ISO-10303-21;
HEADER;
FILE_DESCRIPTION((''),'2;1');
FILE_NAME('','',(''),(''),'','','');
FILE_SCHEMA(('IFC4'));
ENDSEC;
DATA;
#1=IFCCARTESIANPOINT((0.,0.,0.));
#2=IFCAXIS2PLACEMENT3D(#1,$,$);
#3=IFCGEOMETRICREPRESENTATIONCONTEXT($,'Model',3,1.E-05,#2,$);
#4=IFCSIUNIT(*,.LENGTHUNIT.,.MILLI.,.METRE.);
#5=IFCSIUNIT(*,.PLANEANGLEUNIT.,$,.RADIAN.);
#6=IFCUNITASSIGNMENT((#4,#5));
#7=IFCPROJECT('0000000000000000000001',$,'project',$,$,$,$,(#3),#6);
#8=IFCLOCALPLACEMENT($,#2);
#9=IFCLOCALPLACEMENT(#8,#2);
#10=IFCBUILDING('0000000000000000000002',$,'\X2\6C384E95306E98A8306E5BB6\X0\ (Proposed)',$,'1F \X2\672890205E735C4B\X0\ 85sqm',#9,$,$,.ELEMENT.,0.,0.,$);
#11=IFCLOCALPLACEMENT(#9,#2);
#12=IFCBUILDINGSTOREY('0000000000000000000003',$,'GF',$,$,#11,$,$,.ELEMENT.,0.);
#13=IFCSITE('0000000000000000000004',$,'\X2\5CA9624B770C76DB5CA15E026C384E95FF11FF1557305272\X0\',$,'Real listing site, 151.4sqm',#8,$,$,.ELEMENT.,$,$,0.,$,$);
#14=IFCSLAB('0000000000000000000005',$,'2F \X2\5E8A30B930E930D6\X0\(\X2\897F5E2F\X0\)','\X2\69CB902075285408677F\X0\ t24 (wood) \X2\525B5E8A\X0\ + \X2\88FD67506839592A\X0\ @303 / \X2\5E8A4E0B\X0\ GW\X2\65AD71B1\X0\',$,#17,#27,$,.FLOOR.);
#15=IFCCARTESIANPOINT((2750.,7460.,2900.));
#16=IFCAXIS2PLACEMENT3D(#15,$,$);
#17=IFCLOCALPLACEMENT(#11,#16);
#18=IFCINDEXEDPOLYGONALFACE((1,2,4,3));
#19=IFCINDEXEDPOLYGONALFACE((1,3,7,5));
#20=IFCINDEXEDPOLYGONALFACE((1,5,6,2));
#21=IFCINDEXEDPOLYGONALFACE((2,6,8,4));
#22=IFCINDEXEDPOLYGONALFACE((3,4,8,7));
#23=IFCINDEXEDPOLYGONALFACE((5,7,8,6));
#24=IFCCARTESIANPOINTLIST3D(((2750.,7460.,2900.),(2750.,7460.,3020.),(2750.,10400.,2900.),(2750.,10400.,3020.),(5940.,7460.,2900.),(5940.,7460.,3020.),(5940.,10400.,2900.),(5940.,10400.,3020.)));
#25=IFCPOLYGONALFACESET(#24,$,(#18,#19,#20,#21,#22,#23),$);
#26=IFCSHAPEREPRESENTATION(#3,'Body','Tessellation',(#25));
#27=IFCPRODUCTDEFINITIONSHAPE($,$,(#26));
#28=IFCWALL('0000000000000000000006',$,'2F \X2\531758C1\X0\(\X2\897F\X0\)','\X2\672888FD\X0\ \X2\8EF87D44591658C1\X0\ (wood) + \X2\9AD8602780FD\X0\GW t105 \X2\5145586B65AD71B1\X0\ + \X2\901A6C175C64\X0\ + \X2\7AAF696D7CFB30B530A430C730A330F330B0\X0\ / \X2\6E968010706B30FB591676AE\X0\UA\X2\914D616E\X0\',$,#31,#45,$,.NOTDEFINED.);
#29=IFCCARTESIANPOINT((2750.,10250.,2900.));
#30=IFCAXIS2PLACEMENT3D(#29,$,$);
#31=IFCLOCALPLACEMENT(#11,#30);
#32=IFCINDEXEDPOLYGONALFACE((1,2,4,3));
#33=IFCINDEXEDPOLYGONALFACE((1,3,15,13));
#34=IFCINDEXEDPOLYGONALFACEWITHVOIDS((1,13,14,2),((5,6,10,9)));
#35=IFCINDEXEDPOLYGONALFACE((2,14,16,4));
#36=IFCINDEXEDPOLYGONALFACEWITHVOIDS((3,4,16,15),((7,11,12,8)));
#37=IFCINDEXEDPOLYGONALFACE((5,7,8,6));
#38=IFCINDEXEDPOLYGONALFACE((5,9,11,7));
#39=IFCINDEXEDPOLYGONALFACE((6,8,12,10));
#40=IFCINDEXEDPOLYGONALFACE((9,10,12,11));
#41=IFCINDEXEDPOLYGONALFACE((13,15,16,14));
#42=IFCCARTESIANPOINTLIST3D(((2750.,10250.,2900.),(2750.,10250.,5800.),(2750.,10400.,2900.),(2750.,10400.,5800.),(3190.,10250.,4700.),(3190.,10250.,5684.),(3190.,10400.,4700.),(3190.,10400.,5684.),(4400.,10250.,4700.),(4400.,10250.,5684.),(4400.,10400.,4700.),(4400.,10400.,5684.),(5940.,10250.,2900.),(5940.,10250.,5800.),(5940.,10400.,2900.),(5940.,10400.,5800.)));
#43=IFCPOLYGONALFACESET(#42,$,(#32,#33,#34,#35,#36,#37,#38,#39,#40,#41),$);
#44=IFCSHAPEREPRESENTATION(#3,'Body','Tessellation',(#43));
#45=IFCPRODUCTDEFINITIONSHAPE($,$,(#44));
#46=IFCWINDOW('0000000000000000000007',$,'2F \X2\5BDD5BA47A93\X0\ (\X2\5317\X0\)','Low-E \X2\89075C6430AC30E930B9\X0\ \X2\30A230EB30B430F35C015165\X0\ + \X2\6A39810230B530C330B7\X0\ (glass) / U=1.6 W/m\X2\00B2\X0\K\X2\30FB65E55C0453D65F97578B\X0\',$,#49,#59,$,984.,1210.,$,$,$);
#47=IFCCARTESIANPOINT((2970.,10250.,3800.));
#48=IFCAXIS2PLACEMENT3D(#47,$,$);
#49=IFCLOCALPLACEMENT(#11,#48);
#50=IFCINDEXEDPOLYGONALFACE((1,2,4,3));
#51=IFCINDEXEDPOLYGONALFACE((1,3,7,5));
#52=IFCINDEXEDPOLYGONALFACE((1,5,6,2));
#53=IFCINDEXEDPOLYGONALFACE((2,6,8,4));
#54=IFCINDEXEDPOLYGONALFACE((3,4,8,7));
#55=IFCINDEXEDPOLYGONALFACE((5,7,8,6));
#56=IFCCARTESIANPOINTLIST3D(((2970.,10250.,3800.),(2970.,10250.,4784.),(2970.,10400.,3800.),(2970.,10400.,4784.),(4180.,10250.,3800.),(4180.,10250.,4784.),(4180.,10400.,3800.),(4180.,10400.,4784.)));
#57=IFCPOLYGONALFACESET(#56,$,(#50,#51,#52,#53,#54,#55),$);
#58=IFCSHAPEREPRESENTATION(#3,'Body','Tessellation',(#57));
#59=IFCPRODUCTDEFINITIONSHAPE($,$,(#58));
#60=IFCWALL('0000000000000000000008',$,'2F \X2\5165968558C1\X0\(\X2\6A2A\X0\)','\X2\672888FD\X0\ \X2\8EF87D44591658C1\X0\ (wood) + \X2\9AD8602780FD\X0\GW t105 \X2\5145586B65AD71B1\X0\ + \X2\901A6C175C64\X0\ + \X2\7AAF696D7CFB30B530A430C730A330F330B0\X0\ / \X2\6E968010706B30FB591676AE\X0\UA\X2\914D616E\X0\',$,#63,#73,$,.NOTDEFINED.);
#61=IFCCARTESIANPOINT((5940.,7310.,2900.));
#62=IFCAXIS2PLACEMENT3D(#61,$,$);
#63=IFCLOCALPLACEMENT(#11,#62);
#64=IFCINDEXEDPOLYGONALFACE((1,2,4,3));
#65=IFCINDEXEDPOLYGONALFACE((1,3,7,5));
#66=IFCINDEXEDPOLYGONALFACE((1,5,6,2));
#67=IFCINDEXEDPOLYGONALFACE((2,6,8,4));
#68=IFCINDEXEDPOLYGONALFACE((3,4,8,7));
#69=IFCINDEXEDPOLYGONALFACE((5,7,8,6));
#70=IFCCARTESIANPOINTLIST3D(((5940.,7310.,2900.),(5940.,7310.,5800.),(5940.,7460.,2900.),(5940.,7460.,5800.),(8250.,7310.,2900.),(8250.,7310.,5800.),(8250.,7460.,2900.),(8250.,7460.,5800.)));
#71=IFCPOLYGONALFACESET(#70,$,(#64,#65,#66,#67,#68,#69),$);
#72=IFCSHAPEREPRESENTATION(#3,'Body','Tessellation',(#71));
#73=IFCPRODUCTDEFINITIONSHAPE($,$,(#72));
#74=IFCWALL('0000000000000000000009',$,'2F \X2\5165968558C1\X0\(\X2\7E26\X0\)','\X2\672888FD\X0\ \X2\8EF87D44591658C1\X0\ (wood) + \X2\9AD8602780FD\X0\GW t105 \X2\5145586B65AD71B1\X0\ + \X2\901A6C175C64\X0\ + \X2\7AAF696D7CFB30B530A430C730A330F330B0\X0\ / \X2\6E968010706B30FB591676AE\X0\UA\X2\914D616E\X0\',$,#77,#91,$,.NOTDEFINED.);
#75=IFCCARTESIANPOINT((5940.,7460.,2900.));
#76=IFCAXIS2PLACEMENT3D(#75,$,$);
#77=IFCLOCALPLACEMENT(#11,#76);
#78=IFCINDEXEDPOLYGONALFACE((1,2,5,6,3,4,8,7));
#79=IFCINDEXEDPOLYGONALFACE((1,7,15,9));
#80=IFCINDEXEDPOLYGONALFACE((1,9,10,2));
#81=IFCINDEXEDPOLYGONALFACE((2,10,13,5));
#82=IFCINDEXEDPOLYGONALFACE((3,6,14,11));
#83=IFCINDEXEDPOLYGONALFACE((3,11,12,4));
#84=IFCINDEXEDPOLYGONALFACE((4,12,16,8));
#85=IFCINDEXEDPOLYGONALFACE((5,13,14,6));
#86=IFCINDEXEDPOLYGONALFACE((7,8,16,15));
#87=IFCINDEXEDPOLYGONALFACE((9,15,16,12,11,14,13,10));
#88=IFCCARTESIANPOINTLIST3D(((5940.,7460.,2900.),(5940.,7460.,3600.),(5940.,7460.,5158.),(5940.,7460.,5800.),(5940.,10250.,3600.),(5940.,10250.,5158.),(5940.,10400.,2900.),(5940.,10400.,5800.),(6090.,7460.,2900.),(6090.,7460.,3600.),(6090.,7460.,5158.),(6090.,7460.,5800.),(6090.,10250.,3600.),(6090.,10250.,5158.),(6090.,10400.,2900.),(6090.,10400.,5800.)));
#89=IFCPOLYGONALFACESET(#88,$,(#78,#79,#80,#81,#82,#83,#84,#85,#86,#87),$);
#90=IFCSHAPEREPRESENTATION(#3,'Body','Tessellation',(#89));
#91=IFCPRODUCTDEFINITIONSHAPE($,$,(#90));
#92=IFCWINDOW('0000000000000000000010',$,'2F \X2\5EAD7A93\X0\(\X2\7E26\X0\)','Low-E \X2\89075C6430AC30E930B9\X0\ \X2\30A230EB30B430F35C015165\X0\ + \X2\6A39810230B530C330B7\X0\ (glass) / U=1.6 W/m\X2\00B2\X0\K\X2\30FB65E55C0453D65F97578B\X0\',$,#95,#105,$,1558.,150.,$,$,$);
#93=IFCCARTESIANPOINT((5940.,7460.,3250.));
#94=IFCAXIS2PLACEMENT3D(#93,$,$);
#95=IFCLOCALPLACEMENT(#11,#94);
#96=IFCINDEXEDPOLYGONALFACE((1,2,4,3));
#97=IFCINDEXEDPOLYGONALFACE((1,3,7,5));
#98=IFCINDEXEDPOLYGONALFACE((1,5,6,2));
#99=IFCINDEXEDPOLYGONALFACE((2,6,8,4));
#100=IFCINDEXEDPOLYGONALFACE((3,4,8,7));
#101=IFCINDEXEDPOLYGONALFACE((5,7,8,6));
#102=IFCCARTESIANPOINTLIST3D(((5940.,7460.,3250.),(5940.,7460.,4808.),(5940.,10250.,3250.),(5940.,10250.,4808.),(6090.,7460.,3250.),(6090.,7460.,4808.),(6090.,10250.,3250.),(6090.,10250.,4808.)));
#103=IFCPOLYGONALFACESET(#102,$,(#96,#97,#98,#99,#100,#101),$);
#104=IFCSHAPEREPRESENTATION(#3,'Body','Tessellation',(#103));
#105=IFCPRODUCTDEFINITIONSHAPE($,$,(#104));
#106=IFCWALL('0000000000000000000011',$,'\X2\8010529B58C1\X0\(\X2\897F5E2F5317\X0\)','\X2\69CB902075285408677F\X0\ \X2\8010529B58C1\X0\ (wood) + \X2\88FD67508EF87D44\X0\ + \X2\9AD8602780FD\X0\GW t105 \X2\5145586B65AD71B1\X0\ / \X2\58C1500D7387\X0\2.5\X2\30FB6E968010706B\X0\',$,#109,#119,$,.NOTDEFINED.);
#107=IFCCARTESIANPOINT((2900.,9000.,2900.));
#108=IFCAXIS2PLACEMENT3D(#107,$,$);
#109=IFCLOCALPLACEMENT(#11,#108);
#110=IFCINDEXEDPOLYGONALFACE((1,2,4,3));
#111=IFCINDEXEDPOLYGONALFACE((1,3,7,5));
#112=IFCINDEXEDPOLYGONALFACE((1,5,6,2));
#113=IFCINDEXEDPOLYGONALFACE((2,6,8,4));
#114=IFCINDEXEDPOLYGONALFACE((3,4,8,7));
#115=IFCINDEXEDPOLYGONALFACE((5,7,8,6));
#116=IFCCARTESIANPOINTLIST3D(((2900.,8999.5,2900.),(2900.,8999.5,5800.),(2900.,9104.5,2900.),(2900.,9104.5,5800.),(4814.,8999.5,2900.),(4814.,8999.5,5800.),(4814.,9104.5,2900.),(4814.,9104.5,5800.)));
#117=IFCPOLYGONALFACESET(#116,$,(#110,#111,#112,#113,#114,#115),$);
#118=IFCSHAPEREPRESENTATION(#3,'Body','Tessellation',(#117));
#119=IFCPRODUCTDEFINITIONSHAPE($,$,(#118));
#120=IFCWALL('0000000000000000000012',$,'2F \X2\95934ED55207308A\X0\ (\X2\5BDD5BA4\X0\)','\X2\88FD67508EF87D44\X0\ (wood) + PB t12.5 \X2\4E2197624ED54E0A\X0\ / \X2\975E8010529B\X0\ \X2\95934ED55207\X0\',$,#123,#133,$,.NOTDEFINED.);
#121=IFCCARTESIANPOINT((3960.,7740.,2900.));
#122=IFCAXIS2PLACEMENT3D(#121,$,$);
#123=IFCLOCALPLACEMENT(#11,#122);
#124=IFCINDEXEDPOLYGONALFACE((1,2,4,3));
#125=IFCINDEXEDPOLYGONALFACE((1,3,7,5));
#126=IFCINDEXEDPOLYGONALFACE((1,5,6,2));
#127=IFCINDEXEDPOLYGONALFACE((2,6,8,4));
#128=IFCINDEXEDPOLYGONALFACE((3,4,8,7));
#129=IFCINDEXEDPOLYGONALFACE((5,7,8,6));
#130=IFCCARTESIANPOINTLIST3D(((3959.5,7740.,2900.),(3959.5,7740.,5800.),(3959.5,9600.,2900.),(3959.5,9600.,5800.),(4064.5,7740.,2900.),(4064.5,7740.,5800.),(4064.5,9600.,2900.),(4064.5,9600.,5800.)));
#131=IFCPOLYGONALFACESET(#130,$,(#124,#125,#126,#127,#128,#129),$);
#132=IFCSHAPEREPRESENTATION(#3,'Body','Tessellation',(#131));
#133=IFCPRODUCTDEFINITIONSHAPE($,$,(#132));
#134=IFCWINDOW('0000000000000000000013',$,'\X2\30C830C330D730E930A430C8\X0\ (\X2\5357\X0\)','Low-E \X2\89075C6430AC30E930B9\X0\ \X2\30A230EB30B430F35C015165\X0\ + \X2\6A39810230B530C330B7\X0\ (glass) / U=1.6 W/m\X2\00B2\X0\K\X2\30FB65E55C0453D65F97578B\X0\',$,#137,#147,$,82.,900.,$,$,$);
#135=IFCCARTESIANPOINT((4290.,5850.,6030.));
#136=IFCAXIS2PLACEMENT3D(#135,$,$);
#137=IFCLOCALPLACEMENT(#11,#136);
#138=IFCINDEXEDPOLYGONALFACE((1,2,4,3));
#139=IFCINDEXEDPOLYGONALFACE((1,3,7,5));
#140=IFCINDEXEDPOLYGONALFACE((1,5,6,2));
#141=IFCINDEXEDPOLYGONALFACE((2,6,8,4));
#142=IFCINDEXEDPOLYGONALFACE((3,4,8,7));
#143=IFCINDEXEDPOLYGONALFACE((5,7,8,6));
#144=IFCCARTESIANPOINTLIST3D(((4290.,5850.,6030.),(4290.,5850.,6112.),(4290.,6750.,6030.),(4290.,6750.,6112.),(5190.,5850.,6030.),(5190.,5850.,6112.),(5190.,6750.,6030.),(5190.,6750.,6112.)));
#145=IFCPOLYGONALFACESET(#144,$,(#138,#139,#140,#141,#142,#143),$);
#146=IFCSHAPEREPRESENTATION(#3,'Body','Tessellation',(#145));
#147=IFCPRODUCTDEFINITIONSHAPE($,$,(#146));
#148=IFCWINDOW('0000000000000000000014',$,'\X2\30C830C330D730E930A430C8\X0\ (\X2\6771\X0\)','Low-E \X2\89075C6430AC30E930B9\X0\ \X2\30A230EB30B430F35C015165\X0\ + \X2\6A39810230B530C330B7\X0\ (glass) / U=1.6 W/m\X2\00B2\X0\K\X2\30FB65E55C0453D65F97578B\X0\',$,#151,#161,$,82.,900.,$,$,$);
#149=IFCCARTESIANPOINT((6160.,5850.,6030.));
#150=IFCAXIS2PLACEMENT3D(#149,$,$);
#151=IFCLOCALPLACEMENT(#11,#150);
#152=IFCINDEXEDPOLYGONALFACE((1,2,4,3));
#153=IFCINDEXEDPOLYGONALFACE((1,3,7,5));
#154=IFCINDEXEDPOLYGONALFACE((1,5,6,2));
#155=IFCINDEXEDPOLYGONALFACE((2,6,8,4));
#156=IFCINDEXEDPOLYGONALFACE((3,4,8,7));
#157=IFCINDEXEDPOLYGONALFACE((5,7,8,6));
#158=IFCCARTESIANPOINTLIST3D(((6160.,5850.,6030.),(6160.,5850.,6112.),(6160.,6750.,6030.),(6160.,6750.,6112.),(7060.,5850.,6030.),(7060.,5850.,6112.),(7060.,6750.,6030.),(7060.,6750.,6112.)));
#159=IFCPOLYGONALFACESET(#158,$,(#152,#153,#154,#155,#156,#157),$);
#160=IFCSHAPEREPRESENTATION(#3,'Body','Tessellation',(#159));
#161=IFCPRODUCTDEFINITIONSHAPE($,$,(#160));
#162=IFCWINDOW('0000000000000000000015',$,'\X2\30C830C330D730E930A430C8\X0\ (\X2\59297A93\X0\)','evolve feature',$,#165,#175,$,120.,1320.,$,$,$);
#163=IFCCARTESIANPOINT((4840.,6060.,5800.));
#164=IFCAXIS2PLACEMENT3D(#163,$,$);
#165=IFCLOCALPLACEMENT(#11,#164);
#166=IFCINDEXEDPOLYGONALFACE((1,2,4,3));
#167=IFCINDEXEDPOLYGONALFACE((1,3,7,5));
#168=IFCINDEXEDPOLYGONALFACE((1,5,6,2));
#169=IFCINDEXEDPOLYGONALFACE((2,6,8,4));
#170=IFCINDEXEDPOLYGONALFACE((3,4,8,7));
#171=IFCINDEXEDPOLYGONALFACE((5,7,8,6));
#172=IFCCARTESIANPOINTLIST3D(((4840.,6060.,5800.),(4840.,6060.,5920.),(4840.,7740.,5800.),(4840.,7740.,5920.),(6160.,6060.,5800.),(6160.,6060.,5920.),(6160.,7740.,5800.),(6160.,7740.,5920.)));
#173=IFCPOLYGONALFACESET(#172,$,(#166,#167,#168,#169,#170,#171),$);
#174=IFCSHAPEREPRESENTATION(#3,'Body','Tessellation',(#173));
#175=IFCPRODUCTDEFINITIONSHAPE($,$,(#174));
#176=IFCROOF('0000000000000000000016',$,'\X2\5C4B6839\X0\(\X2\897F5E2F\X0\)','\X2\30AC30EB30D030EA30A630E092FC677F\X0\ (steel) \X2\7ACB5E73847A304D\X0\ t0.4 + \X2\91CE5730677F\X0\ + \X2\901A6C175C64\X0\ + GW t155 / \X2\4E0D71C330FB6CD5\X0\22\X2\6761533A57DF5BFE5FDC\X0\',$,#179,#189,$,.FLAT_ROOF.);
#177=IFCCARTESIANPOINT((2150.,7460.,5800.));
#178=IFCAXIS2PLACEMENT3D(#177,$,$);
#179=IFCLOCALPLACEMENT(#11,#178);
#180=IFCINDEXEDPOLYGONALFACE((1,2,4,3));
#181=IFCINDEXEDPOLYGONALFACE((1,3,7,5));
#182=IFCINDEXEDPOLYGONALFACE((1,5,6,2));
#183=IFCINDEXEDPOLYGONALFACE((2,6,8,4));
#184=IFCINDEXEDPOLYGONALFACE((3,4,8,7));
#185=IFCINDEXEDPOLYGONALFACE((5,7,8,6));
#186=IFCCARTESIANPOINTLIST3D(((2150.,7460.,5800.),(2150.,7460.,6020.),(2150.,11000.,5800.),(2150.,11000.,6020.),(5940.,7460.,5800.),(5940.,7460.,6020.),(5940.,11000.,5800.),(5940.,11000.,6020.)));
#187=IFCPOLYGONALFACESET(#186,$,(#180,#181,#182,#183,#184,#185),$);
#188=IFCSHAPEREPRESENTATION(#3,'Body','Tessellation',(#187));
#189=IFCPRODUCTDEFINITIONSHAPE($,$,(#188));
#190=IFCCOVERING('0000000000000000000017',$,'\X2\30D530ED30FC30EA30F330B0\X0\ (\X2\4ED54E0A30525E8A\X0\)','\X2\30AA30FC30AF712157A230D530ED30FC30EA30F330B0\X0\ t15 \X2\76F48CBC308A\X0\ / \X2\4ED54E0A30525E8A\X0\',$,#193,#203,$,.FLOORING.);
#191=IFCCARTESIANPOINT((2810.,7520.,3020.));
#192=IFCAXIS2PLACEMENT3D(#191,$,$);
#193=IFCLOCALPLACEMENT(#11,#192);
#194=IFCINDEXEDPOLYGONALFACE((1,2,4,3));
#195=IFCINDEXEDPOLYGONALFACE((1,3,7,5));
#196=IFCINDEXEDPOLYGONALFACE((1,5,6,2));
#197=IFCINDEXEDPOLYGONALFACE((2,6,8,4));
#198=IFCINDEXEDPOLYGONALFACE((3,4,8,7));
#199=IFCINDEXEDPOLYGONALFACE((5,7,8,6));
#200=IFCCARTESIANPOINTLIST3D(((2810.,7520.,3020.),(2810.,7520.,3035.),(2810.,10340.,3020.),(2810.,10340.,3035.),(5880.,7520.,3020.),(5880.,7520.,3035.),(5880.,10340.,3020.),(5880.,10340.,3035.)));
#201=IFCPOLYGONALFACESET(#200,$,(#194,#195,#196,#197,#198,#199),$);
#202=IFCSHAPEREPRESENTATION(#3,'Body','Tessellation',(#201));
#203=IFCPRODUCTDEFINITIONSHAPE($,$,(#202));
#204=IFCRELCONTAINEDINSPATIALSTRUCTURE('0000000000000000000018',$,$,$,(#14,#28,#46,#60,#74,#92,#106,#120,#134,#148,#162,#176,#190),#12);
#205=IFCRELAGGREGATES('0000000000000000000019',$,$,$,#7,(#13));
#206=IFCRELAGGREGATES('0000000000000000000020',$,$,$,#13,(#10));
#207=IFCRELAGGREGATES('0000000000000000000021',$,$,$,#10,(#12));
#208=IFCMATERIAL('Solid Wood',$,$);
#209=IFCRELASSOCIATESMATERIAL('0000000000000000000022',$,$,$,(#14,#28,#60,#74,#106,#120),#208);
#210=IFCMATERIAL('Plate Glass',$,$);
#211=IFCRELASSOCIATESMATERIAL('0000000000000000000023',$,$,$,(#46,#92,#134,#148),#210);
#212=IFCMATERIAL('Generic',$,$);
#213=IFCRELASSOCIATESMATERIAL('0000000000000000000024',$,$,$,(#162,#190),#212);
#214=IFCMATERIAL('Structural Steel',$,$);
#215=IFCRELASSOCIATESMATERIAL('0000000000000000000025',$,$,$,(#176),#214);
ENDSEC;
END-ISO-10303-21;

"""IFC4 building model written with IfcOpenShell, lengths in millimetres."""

from ifc_helpers import new_model, si_unit, frame, frame_2d, origin, place, context, project, spatial, rectangle, extrude, material, element, fill, save


model = new_model("IFC4")

# Units and contexts
model_context = context("Model", 3, precision=1e-05, world=origin())
ifc_project = project(units=[si_unit("LENGTHUNIT", "METRE", prefix="MILLI"), si_unit("PLANEANGLEUNIT", "RADIAN")], contexts=[model_context])

# Site, building, storey
site_placement = place(None, origin())
site = spatial("IfcSite", under=ifc_project, at=site_placement, Name="岩手県盛岡市永井１５地割", ObjectType="Real listing site, 151.4sqm", CompositionType="ELEMENT", RefElevation=0.0)
building_placement = place(site_placement, origin())
building = spatial("IfcBuilding", under=site, at=building_placement, Name="永井の風の家 (Proposed)", ObjectType="1F 木造平屋 85sqm", CompositionType="ELEMENT", ElevationOfRefHeight=0.0, ElevationOfTerrain=0.0)
storey_placement = place(building_placement, origin())
storey = spatial("IfcBuildingStorey", under=building, at=storey_placement, Name="GF", CompositionType="ELEMENT", Elevation=0.0)

# Slab
ifc_material_1 = material(Name="Solid Wood")
slab_placement = place(storey_placement, frame((2750.0, 7460.0, 2900.0)))
element("IfcSlab", 1, at=slab_placement, inside=storey, material=ifc_material_1, Name="2F 床スラブ(西帯)", Description="構造用合板 t24 (wood) 剛床 + 製材根太 @303 / 床下 GW断熱", PredefinedType="FLOOR", context=model_context, shape_type="SweptSolid", body=[
    extrude(rectangle(XDim=3190.0, YDim=2940.0, at=frame_2d((1595.0, 1470.0))), frame((2750.0, 7460.0, 2900.0)), (0.0, 0.0, 1.0), 120.0),
])

# Wall, opening, window
wall_1_placement = place(storey_placement, frame((2750.0, 10250.0, 2900.0)))
wall_1 = element("IfcWall", 2, at=wall_1_placement, inside=storey, material=ifc_material_1, Name="2F 北壁(西)", Description="木製 軸組外壁 (wood) + 高性能GW t105 充填断熱 + 通気層 + 窯業系サイディング / 準耐火・外皮UA配慮", PredefinedType="NOTDEFINED", context=model_context, shape_type="SweptSolid", body=[
    extrude(rectangle(XDim=3190.0, YDim=150.0, at=frame_2d((1595.0, 75.0))), frame((2750.0, 10250.0, 2900.0)), (0.0, 0.0, 1.0), 2900.0),
])
opening_1_placement = place(storey_placement, frame((2970.0, 10250.0, 3800.0)))
opening_1 = element("IfcOpeningElement", 3, at=opening_1_placement, cuts=wall_1, PredefinedType="NOTDEFINED", context=model_context, shape_type="SweptSolid", body=[
    extrude(rectangle(XDim=1210.0, YDim=150.0, at=frame_2d((605.0, 75.0))), frame((2970.0, 10250.0, 3800.0)), (0.0, 0.0, 1.0), 984.0),
])
ifc_material_2 = material(Name="Plate Glass")
window_1_placement = place(storey_placement, frame((2970.0, 10250.0, 3800.0)))
window_1 = element("IfcWindow", 4, at=window_1_placement, inside=storey, material=ifc_material_2, Name="2F 寝室窓 (北)", Description="Low-E 複層ガラス アルゴン封入 + 樹脂サッシ (glass) / U=1.6 W/m²K・日射取得型", OverallHeight=984.0, OverallWidth=1210.0, context=model_context, shape_type="SweptSolid", body=[
    extrude(rectangle(XDim=1210.0, YDim=150.0, at=frame_2d((605.0, 75.0))), frame((2970.0, 10250.0, 3800.0)), (0.0, 0.0, 1.0), 984.0),
])
fill(opening_1, window_1)

# Wall
wall_2_placement = place(storey_placement, frame((5940.0, 7310.0, 2900.0)))
element("IfcWall", 5, at=wall_2_placement, inside=storey, material=ifc_material_1, Name="2F 入隅壁(横)", Description="木製 軸組外壁 (wood) + 高性能GW t105 充填断熱 + 通気層 + 窯業系サイディング / 準耐火・外皮UA配慮", PredefinedType="NOTDEFINED", context=model_context, shape_type="SweptSolid", body=[
    extrude(rectangle(XDim=2310.0, YDim=150.0, at=frame_2d((1155.0, 75.0))), frame((5940.0, 7310.0, 2900.0)), (0.0, 0.0, 1.0), 2900.0),
])

# Wall, opening, window
wall_3_placement = place(storey_placement, frame((5940.0, 7460.0, 2900.0)))
wall_3 = element("IfcWall", 6, at=wall_3_placement, inside=storey, material=ifc_material_1, Name="2F 入隅壁(縦)", Description="木製 軸組外壁 (wood) + 高性能GW t105 充填断熱 + 通気層 + 窯業系サイディング / 準耐火・外皮UA配慮", PredefinedType="NOTDEFINED", context=model_context, shape_type="SweptSolid", body=[
    extrude(rectangle(XDim=150.0, YDim=2940.0, at=frame_2d((75.0, 1470.0))), frame((5940.0, 7460.0, 2900.0)), (0.0, 0.0, 1.0), 2900.0),
])
opening_2_placement = place(storey_placement, frame((5940.0, 7460.0, 3250.0)))
opening_2 = element("IfcOpeningElement", 7, at=opening_2_placement, cuts=wall_3, PredefinedType="NOTDEFINED", context=model_context, shape_type="SweptSolid", body=[
    extrude(rectangle(XDim=150.0, YDim=2790.0, at=frame_2d((75.0, 1395.0))), frame((5940.0, 7460.0, 3250.0)), (0.0, 0.0, 1.0), 1558.0),
])
window_2_placement = place(storey_placement, frame((5940.0, 7460.0, 3250.0)))
window_2 = element("IfcWindow", 8, at=window_2_placement, inside=storey, material=ifc_material_2, Name="2F 庭窓(縦)", Description="Low-E 複層ガラス アルゴン封入 + 樹脂サッシ (glass) / U=1.6 W/m²K・日射取得型", OverallHeight=1558.0, OverallWidth=150.0, context=model_context, shape_type="SweptSolid", body=[
    extrude(rectangle(XDim=150.0, YDim=2790.0, at=frame_2d((75.0, 1395.0))), frame((5940.0, 7460.0, 3250.0)), (0.0, 0.0, 1.0), 1558.0),
])
fill(opening_2, window_2)

# Walls
wall_4_placement = place(storey_placement, frame((2900.0, 9000.0, 2900.0)))
element("IfcWall", 9, at=wall_4_placement, inside=storey, material=ifc_material_1, Name="耐力壁(西帯北)", Description="構造用合板 耐力壁 (wood) + 製材軸組 + 高性能GW t105 充填断熱 / 壁倍率2.5・準耐火", PredefinedType="NOTDEFINED", context=model_context, shape_type="SweptSolid", body=[
    extrude(rectangle(XDim=1914.0, YDim=105.0, at=frame_2d((957.0, 52.0))), frame((2900.0, 9000.0, 2900.0)), (0.0, 0.0, 1.0), 2900.0),
])
wall_5_placement = place(storey_placement, frame((3960.0, 7740.0, 2900.0)))
element("IfcWall", 10, at=wall_5_placement, inside=storey, material=ifc_material_1, Name="2F 間仕切り (寝室)", Description="製材軸組 (wood) + PB t12.5 両面仕上 / 非耐力 間仕切", PredefinedType="NOTDEFINED", context=model_context, shape_type="SweptSolid", body=[
    extrude(rectangle(XDim=105.0, YDim=1860.0, at=frame_2d((52.0, 930.0))), frame((3960.0, 7740.0, 2900.0)), (0.0, 0.0, 1.0), 2900.0),
])

# Windows
window_3_placement = place(storey_placement, frame((4290.0, 5850.0, 6030.0)))
element("IfcWindow", 11, at=window_3_placement, inside=storey, material=ifc_material_2, Name="トップライト (南)", Description="Low-E 複層ガラス アルゴン封入 + 樹脂サッシ (glass) / U=1.6 W/m²K・日射取得型", OverallHeight=82.0, OverallWidth=900.0, context=model_context, shape_type="SweptSolid", body=[
    extrude(rectangle(XDim=900.0, YDim=900.0, at=frame_2d((450.0, 450.0))), frame((4290.0, 5850.0, 6030.0)), (0.0, 0.0, 1.0), 82.0),
])
window_4_placement = place(storey_placement, frame((6160.0, 5850.0, 6030.0)))
element("IfcWindow", 12, at=window_4_placement, inside=storey, material=ifc_material_2, Name="トップライト (東)", Description="Low-E 複層ガラス アルゴン封入 + 樹脂サッシ (glass) / U=1.6 W/m²K・日射取得型", OverallHeight=82.0, OverallWidth=900.0, context=model_context, shape_type="SweptSolid", body=[
    extrude(rectangle(XDim=900.0, YDim=900.0, at=frame_2d((450.0, 450.0))), frame((6160.0, 5850.0, 6030.0)), (0.0, 0.0, 1.0), 82.0),
])
ifc_material_3 = material(Name="Generic")
window_5_placement = place(storey_placement, frame((4840.0, 6060.0, 5800.0)))
element("IfcWindow", 13, at=window_5_placement, inside=storey, material=ifc_material_3, Name="トップライト (天窓)", Description="evolve feature", OverallHeight=120.0, OverallWidth=1320.0, context=model_context, shape_type="SweptSolid", body=[
    extrude(rectangle(XDim=1320.0, YDim=1680.0, at=frame_2d((660.0, 840.0))), frame((4840.0, 6060.0, 5800.0)), (0.0, 0.0, 1.0), 120.0),
])

# Roof
ifc_material_4 = material(Name="Structural Steel")
for number, where, name in (
    (14, (2150.0, 7460.0, 5800.0), "屋根(西帯)"),
):
    element("IfcRoof", number, at=place(storey_placement, frame(where)), inside=storey, material=ifc_material_4, Name=name, Description="ガルバリウム鋼板 (steel) 立平葺き t0.4 + 野地板 + 通気層 + GW t155 / 不燃・法22条区域対応", PredefinedType="FLAT_ROOF", context=model_context, shape_type="SweptSolid", body=[
        extrude(rectangle(XDim=3790.0, YDim=3540.0, at=frame_2d((1895.0, 1770.0))), frame((2150.0, 7460.0, 5800.0)), (0.0, 0.0, 1.0), 220.0),
    ])

# Covering
covering_placement = place(storey_placement, frame((2810.0, 7520.0, 3020.0)))
element("IfcCovering", 15, at=covering_placement, inside=storey, material=ifc_material_3, Name="フローリング (仕上げ床)", Description="オーク無垢フローリング t15 直貼り / 仕上げ床", PredefinedType="FLOORING", context=model_context, shape_type="SweptSolid", body=[
    extrude(rectangle(XDim=3070.0, YDim=2820.0, at=frame_2d((1535.0, 1410.0))), frame((2810.0, 7520.0, 3020.0)), (0.0, 0.0, 1.0), 15.0),
])

save(model, "model.ifc")
